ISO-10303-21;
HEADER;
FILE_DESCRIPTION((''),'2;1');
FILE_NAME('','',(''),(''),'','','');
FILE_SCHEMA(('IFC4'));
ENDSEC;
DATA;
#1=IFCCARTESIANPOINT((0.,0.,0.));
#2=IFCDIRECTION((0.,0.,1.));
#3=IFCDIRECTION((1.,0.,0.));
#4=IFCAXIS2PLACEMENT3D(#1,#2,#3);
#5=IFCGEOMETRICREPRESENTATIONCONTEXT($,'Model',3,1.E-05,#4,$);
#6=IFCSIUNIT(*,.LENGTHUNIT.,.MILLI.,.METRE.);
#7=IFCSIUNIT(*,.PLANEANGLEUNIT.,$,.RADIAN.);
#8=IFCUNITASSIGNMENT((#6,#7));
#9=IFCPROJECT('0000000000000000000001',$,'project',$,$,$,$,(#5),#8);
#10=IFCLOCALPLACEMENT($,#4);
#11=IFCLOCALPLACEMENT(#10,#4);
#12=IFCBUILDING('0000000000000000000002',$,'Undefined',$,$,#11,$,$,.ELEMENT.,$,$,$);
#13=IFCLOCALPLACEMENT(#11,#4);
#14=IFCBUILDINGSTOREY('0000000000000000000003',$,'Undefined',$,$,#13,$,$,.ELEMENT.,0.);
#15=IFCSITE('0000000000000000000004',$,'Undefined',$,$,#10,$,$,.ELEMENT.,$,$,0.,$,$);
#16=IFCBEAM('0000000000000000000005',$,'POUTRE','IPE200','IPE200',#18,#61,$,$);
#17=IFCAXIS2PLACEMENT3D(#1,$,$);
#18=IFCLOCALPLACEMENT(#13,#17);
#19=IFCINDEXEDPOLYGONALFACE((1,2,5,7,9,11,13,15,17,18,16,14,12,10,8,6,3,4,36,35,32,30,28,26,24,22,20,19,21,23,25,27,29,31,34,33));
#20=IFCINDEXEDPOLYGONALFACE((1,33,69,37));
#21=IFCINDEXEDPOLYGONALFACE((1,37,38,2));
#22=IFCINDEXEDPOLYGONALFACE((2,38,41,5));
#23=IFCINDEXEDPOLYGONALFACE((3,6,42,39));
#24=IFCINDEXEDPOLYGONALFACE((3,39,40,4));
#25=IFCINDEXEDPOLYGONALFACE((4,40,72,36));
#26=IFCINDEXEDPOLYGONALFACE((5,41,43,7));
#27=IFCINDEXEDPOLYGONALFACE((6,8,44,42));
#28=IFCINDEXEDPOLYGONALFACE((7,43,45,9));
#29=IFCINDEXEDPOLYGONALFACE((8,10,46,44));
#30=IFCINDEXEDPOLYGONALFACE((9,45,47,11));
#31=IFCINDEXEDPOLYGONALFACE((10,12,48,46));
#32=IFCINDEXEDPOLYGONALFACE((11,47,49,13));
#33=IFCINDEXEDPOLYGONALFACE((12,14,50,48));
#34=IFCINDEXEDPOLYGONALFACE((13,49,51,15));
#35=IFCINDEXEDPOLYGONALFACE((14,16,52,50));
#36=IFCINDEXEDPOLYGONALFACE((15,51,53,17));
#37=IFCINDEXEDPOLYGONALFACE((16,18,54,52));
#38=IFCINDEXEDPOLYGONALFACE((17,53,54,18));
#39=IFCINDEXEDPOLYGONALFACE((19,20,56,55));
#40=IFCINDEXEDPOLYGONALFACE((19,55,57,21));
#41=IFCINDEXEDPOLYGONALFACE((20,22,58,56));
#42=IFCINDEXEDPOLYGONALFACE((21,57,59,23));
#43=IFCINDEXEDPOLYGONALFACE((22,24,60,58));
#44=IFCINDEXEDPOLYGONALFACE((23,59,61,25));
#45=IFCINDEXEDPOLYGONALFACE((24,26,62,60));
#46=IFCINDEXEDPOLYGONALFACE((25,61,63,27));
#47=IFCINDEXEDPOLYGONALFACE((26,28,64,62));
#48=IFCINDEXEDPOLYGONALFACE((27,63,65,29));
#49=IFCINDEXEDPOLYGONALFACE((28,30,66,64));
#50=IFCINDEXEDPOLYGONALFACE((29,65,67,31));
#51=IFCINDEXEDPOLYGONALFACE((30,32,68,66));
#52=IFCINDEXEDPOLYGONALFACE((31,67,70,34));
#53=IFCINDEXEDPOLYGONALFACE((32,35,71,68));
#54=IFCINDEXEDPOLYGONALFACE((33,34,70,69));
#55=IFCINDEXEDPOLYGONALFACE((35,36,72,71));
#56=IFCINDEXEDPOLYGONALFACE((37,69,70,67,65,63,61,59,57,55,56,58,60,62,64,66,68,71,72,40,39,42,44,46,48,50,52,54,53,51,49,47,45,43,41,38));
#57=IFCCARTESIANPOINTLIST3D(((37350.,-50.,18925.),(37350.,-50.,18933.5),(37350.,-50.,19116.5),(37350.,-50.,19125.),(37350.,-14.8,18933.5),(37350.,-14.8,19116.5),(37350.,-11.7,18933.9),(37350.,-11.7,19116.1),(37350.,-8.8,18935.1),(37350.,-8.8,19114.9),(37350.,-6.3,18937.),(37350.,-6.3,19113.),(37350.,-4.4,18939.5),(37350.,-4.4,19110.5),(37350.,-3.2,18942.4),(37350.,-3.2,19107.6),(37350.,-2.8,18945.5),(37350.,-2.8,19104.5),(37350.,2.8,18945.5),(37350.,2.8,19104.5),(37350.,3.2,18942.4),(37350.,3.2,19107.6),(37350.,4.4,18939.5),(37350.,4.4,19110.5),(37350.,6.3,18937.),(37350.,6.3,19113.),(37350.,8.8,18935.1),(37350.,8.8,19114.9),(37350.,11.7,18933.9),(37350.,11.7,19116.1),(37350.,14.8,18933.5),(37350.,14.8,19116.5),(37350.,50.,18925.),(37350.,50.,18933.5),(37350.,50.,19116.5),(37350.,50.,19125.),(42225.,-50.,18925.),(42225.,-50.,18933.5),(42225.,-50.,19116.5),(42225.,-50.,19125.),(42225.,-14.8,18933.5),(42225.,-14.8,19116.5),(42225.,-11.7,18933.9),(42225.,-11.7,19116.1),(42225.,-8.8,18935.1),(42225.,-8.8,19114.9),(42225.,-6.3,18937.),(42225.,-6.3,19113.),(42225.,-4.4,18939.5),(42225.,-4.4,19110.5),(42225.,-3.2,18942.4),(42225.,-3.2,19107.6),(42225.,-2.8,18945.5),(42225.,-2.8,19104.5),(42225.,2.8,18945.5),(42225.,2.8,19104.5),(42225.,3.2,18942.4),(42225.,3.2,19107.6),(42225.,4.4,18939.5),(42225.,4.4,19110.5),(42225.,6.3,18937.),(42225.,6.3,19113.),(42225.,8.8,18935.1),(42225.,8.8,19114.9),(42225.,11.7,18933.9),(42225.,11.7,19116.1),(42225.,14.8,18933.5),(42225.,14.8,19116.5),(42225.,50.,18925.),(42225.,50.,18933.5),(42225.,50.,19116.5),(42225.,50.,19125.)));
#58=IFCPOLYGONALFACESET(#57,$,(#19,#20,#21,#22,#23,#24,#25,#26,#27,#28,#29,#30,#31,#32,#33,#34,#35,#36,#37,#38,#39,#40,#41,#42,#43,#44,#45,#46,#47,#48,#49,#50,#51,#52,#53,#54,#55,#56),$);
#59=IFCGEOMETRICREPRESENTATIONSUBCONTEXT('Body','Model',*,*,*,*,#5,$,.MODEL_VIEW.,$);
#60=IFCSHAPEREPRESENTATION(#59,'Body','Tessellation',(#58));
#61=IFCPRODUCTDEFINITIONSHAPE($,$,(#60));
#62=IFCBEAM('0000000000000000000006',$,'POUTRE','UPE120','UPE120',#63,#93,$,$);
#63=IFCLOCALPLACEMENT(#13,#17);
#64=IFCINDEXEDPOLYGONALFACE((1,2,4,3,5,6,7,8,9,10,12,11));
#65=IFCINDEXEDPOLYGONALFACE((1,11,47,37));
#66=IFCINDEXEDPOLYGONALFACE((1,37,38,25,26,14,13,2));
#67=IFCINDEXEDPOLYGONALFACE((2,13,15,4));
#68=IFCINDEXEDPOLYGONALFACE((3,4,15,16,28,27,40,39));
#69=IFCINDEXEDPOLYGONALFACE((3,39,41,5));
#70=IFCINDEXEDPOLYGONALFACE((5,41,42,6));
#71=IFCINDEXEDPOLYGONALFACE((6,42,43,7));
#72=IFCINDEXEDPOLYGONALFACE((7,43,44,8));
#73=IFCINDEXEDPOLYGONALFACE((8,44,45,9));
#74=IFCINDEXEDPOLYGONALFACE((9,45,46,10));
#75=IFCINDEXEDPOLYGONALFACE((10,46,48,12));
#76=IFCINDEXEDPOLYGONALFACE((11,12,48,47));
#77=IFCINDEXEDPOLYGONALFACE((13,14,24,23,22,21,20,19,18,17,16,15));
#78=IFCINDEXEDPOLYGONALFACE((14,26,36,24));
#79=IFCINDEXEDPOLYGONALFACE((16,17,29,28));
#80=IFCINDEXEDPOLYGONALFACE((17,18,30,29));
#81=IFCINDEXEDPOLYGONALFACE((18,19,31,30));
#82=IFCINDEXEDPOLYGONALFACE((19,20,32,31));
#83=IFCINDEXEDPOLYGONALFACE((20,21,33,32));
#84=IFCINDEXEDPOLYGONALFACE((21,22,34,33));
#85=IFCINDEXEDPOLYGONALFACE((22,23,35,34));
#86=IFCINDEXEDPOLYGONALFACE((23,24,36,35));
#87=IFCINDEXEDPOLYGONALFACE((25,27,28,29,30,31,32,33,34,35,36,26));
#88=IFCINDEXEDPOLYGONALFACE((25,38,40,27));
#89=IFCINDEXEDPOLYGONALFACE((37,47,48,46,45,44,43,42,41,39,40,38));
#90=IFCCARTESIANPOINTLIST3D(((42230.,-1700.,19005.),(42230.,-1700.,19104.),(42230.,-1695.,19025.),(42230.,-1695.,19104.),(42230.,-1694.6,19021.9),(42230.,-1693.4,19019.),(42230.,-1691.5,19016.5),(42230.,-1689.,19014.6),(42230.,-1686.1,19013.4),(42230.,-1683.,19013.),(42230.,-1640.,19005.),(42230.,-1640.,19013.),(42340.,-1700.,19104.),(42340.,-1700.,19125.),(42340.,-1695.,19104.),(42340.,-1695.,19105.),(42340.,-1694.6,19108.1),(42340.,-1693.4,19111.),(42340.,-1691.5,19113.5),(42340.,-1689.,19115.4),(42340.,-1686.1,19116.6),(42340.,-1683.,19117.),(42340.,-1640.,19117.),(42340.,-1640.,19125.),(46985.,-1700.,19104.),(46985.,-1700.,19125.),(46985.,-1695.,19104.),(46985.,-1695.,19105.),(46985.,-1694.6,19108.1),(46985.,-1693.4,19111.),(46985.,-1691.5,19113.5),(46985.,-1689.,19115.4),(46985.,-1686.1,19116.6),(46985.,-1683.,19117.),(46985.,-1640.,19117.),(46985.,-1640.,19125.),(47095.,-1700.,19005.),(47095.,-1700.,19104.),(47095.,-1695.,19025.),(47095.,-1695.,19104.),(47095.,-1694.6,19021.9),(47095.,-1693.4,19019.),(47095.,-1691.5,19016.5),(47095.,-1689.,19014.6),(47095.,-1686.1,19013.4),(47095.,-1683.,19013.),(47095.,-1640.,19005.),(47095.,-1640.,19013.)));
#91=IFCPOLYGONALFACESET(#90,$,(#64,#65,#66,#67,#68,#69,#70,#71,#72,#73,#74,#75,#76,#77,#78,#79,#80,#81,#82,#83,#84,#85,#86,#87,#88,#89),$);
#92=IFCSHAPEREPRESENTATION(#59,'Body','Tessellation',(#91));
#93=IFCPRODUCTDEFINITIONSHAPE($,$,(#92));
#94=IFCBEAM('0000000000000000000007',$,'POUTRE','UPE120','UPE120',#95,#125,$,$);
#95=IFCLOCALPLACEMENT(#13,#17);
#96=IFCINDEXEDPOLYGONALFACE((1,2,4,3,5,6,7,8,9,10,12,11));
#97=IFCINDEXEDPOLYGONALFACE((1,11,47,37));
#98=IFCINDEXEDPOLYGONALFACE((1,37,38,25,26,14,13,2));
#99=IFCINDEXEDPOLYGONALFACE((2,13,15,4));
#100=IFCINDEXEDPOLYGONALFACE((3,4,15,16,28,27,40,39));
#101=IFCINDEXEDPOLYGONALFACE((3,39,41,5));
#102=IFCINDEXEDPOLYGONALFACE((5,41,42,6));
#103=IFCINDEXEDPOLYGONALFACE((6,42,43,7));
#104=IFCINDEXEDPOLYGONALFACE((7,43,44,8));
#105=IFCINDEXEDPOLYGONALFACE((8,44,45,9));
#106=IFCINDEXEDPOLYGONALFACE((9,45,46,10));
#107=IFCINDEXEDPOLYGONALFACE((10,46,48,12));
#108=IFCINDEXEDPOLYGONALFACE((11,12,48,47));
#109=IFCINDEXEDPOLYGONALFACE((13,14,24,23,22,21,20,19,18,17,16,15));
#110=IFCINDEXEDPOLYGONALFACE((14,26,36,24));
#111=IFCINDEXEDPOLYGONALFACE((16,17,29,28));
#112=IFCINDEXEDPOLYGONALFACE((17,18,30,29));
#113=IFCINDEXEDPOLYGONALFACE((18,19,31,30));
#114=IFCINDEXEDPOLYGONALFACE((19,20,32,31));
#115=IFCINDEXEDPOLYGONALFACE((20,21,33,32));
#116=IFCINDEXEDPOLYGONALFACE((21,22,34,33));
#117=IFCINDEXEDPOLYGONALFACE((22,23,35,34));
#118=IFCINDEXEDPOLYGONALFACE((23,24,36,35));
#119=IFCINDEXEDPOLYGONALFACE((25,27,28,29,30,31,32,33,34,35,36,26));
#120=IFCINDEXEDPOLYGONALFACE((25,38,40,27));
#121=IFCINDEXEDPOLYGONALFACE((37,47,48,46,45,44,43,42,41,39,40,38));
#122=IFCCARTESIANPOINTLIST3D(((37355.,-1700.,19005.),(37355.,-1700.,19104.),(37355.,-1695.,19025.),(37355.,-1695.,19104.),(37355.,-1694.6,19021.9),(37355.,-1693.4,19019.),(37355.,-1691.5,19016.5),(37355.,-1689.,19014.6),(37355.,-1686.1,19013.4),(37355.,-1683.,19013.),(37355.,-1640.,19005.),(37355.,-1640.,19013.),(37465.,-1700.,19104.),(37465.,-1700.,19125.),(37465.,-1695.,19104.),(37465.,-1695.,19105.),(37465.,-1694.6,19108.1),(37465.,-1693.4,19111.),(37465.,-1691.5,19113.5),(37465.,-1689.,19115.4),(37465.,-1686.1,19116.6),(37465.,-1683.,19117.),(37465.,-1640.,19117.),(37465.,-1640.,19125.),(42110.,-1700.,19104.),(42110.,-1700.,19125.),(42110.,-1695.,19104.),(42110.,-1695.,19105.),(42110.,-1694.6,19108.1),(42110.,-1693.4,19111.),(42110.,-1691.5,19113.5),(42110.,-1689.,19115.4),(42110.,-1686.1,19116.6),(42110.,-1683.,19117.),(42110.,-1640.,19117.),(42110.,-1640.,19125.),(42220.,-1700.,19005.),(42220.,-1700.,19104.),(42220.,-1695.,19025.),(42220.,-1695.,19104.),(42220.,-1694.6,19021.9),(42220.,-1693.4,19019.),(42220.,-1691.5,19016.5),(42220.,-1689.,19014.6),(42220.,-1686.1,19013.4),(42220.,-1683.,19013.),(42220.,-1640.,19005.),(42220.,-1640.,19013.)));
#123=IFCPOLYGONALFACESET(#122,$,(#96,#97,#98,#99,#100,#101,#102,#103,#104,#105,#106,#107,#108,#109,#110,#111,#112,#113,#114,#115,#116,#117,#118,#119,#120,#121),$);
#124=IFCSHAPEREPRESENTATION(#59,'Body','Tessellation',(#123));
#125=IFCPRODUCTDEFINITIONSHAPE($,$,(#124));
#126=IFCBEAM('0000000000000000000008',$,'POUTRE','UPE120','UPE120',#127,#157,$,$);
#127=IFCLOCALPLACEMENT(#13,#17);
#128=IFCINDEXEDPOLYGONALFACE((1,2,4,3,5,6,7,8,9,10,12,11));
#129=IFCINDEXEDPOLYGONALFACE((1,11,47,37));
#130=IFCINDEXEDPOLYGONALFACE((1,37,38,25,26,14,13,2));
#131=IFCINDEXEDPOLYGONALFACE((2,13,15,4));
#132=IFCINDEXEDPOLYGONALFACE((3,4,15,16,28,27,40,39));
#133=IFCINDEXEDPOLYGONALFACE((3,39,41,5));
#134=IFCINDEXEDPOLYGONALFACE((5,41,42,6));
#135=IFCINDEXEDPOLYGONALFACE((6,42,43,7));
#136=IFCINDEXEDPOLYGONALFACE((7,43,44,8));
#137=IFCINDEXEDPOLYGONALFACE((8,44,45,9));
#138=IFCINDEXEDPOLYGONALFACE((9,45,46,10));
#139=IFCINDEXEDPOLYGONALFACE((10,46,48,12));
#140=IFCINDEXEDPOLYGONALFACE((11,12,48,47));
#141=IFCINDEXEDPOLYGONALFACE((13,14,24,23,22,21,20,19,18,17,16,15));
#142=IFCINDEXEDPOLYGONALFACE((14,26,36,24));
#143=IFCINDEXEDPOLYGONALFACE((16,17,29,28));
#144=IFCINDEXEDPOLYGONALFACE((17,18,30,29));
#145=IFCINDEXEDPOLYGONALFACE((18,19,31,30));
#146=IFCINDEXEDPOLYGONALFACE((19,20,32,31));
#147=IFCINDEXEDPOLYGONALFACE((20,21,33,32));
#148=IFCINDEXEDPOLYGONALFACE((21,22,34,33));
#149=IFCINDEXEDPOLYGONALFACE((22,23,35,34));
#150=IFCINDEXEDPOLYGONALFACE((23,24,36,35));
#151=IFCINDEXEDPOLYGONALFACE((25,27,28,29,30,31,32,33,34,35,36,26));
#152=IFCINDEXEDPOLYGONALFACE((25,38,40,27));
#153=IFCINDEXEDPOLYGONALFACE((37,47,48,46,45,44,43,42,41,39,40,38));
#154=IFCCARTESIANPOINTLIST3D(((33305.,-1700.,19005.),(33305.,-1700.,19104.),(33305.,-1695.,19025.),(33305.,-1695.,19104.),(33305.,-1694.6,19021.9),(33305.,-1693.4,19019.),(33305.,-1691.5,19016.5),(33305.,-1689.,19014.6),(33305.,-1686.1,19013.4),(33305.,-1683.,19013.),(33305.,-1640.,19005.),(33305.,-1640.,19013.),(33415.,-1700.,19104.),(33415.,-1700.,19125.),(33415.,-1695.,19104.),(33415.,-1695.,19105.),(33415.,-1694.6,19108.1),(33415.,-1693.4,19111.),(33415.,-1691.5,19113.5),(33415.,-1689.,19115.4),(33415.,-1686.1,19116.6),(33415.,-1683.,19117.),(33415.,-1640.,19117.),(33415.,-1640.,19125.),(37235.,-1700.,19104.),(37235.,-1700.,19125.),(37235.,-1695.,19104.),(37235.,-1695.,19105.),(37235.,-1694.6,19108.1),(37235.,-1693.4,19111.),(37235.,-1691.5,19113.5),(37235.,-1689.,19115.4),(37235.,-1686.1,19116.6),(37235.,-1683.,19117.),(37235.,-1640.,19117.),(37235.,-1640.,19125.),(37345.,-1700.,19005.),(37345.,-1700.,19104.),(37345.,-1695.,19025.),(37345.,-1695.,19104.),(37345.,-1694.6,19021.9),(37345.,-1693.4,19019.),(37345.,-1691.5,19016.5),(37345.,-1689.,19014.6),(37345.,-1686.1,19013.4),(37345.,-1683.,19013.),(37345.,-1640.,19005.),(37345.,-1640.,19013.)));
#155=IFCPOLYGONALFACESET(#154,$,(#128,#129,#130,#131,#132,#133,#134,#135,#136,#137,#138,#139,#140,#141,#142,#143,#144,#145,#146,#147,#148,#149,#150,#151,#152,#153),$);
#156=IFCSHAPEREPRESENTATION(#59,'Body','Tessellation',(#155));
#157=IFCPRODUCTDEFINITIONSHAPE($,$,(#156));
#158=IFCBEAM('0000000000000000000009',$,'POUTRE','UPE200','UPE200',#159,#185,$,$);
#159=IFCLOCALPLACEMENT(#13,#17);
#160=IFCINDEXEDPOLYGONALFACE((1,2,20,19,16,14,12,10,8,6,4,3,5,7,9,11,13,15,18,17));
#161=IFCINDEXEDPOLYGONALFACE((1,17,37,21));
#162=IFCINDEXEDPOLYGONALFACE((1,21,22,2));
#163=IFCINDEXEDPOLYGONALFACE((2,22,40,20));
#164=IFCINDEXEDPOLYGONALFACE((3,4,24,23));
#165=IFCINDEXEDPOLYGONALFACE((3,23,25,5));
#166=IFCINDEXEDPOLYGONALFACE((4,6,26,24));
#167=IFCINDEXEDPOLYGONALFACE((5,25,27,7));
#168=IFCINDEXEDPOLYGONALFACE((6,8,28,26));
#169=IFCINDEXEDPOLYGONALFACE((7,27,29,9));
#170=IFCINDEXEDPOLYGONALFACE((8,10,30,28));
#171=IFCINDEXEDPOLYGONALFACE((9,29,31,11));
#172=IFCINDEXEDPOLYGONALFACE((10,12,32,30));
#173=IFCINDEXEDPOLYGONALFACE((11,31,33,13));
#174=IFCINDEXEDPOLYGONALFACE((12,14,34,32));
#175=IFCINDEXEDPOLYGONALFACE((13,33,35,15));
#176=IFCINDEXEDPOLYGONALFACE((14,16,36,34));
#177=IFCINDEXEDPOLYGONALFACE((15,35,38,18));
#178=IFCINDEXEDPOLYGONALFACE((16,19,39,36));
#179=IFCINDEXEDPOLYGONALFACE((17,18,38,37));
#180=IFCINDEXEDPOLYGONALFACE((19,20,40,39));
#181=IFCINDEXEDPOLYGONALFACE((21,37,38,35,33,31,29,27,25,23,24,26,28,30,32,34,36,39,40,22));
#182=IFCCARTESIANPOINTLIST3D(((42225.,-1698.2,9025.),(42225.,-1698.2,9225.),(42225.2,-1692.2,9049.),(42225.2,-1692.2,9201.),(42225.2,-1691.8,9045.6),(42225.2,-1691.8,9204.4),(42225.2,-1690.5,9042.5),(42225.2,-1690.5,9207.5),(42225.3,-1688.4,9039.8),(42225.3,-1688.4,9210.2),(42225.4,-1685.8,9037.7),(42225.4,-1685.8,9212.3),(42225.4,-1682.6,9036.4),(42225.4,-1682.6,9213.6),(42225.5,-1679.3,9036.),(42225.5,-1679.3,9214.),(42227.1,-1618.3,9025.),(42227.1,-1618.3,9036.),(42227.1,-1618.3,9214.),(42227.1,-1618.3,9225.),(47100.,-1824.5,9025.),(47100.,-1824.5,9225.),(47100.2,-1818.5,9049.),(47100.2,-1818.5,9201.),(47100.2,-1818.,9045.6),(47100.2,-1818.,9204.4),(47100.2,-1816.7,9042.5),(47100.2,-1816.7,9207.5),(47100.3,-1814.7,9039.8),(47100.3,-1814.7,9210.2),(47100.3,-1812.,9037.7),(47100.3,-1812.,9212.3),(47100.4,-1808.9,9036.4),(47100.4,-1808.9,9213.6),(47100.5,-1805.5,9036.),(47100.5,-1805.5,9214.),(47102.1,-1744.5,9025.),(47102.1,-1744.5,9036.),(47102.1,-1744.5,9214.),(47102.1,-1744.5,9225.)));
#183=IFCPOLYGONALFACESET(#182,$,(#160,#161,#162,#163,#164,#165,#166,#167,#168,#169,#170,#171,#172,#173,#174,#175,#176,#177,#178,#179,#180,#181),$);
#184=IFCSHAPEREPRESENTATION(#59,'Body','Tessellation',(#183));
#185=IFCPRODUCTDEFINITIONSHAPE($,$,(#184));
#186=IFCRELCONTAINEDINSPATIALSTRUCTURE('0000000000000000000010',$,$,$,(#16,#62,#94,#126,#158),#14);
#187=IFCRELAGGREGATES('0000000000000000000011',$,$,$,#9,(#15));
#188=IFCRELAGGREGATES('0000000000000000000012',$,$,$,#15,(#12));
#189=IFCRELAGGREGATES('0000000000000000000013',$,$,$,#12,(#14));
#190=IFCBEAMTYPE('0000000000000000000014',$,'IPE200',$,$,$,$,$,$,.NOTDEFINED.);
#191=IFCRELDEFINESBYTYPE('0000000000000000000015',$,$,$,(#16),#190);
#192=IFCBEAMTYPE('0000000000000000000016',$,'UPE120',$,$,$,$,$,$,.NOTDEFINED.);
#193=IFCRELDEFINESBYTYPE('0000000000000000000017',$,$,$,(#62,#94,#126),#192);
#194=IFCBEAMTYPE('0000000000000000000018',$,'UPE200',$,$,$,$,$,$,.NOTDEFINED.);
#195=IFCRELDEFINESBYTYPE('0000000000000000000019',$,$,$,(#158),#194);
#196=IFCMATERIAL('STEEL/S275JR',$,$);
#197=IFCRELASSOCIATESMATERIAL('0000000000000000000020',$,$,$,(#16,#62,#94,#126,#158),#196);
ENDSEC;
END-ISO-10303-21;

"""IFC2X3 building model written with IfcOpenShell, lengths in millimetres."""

from ifc_helpers import new_model, si_unit, frame, origin_with_axes, origin_2d_with_axis, place, context, subcontext, project, spatial, rectangle, i_section, u_section, extrude, boolean, material, type_object, element, save


model = new_model("IFC2X3")

# Units and contexts
model_context = context("Model", 3, precision=1e-05, world=origin_with_axes())
body_context = subcontext(model_context, "Body", "Model", "MODEL_VIEW")
ifc_project = project(units=[si_unit("LENGTHUNIT", "METRE", prefix="MILLI"), si_unit("PLANEANGLEUNIT", "RADIAN")], contexts=[model_context])

# Site, building, storey
site_placement = place(None, origin_with_axes())
site = spatial("IfcSite", under=ifc_project, at=site_placement, Name="Undefined", CompositionType="ELEMENT", RefElevation=0.0)
building_placement = place(site_placement, origin_with_axes())
building = spatial("IfcBuilding", under=site, at=building_placement, Name="Undefined", CompositionType="ELEMENT")
storey_placement = place(building_placement, origin_with_axes())
storey = spatial("IfcBuildingStorey", under=building, at=storey_placement, Name="Undefined", CompositionType="ELEMENT", Elevation=0.0)

# Shared definitions
ifc_material_1 = material(Name="STEEL/S275JR")

# Beams
beam_type_1 = type_object("IfcBeamType", Name="IPE200", PredefinedType="NOTDEFINED")
for number, where, z_axis, x_axis, name in (
    (1, (37350.0, 0.0, 19025.0), (-0.000006, 0.0, 1.0), (1.0, 0.0, 0.000006), "POUTRE"),
):
    element("IfcBeam", number, at=place(storey_placement, frame(where, z_axis=z_axis, x_axis=x_axis)), inside=storey, type_object=beam_type_1, material=ifc_material_1, Name=name, Description="IPE200", ObjectType="IPE200", context=body_context, shape_type="SweptSolid", body=[
        extrude(i_section(OverallWidth=100.0, OverallDepth=200.0, WebThickness=5.6, FlangeThickness=8.5, FilletRadius=12.0, at=origin_2d_with_axis()), frame((4875.0, 0.0, 0.0), z_axis=(-1.0, 0.0, 0.0), x_axis=(0.0, -1.0, 0.0)), (0.0, 0.0, 1.0), 4875.0),
    ])
beam_type_2 = type_object("IfcBeamType", Name="UPE120", PredefinedType="NOTDEFINED")
for number, where, z_axis, x_axis, name in (
    (2, (42234.7, -1670.0, 19065.0), (0.0, 0.0, -1.0), (1.0, 0.0, 0.0), "POUTRE"),
    (3, (37359.7, -1670.0, 19065.0), (0.0, 0.0, -1.0), (1.0, 0.0, 0.0), "POUTRE"),
):
    element("IfcBeam", number, at=place(storey_placement, frame(where, z_axis=z_axis, x_axis=x_axis)), inside=storey, type_object=beam_type_2, material=ifc_material_1, Name=name, Description="UPE120", ObjectType="UPE120", context=body_context, shape_type="CSG", body=[
        boolean("DIFFERENCE", boolean("DIFFERENCE", extrude(u_section(Depth=120.0, FlangeWidth=60.0, WebThickness=5.0, FlangeThickness=8.0, FilletRadius=12.0, at=origin_2d_with_axis()), frame((4860.3, 0.0, 0.0), z_axis=(-1.0, 0.0, 0.0), x_axis=(0.0, -1.0, 0.0)), (0.0, 0.0, 1.0), 4865.0), extrude(rectangle(XDim=22.0, YDim=112.0, at=origin_2d_with_axis()), frame((49.3, 31.0, -50.0), z_axis=(0.0, -1.0, 0.0), x_axis=(0.0, 0.0, 1.0)), (0.0, 0.0, 1.0), 62.0)), extrude(rectangle(XDim=22.0, YDim=112.0, at=origin_2d_with_axis()), frame((4806.3, -31.0, -50.0), z_axis=(0.0, 1.0, 0.0), x_axis=(0.0, 0.0, 1.0)), (0.0, 0.0, 1.0), 62.0)),
    ])
beam_1_placement = place(storey_placement, frame((33307.5, -1670.0, 19065.0), z_axis=(0.0, 0.0, -1.0), x_axis=(1.0, 0.0, 0.0)))
element("IfcBeam", 4, at=beam_1_placement, inside=storey, type_object=beam_type_2, material=ifc_material_1, Name="POUTRE", Description="UPE120", ObjectType="UPE120", context=body_context, shape_type="CSG", body=[
    boolean("DIFFERENCE", boolean("DIFFERENCE", extrude(u_section(Depth=120.0, FlangeWidth=60.0, WebThickness=5.0, FlangeThickness=8.0, FilletRadius=12.0, at=origin_2d_with_axis()), frame((4037.5, 0.0, 0.0), z_axis=(-1.0, 0.0, 0.0), x_axis=(0.0, -1.0, 0.0)), (0.0, 0.0, 1.0), 4040.0), extrude(rectangle(XDim=22.0, YDim=112.0, at=origin_2d_with_axis()), frame((51.5, 31.0, -50.0), z_axis=(0.0, -1.0, 0.0), x_axis=(0.0, 0.0, 1.0)), (0.0, 0.0, 1.0), 62.0)), extrude(rectangle(XDim=22.0, YDim=112.0, at=origin_2d_with_axis()), frame((3983.5, -31.0, -50.0), z_axis=(0.0, 1.0, 0.0), x_axis=(0.0, 0.0, 1.0)), (0.0, 0.0, 1.0), 62.0)),
])
beam_type_3 = type_object("IfcBeamType", Name="UPE200", PredefinedType="NOTDEFINED")
for number, where, z_axis, x_axis, name in (
    (5, (42226.0, -1658.3, 9125.0), (0.0, 0.0, -1.0), (0.999665, -0.025886, 0.0), "POUTRE"),
):
    element("IfcBeam", number, at=place(storey_placement, frame(where, z_axis=z_axis, x_axis=x_axis)), inside=storey, type_object=beam_type_3, material=ifc_material_1, Name=name, Description="UPE200", ObjectType="UPE200", context=body_context, shape_type="SweptSolid", body=[
        extrude(u_section(Depth=200.0, FlangeWidth=80.0, WebThickness=6.0, FlangeThickness=11.0, FilletRadius=13.0, at=origin_2d_with_axis()), frame((4876.6, 0.0, 0.0), z_axis=(-1.0, 0.0, 0.0), x_axis=(0.0, -1.0, 0.0)), (0.0, 0.0, 1.0), 4876.6),
    ])

save(model, "model.ifc")
